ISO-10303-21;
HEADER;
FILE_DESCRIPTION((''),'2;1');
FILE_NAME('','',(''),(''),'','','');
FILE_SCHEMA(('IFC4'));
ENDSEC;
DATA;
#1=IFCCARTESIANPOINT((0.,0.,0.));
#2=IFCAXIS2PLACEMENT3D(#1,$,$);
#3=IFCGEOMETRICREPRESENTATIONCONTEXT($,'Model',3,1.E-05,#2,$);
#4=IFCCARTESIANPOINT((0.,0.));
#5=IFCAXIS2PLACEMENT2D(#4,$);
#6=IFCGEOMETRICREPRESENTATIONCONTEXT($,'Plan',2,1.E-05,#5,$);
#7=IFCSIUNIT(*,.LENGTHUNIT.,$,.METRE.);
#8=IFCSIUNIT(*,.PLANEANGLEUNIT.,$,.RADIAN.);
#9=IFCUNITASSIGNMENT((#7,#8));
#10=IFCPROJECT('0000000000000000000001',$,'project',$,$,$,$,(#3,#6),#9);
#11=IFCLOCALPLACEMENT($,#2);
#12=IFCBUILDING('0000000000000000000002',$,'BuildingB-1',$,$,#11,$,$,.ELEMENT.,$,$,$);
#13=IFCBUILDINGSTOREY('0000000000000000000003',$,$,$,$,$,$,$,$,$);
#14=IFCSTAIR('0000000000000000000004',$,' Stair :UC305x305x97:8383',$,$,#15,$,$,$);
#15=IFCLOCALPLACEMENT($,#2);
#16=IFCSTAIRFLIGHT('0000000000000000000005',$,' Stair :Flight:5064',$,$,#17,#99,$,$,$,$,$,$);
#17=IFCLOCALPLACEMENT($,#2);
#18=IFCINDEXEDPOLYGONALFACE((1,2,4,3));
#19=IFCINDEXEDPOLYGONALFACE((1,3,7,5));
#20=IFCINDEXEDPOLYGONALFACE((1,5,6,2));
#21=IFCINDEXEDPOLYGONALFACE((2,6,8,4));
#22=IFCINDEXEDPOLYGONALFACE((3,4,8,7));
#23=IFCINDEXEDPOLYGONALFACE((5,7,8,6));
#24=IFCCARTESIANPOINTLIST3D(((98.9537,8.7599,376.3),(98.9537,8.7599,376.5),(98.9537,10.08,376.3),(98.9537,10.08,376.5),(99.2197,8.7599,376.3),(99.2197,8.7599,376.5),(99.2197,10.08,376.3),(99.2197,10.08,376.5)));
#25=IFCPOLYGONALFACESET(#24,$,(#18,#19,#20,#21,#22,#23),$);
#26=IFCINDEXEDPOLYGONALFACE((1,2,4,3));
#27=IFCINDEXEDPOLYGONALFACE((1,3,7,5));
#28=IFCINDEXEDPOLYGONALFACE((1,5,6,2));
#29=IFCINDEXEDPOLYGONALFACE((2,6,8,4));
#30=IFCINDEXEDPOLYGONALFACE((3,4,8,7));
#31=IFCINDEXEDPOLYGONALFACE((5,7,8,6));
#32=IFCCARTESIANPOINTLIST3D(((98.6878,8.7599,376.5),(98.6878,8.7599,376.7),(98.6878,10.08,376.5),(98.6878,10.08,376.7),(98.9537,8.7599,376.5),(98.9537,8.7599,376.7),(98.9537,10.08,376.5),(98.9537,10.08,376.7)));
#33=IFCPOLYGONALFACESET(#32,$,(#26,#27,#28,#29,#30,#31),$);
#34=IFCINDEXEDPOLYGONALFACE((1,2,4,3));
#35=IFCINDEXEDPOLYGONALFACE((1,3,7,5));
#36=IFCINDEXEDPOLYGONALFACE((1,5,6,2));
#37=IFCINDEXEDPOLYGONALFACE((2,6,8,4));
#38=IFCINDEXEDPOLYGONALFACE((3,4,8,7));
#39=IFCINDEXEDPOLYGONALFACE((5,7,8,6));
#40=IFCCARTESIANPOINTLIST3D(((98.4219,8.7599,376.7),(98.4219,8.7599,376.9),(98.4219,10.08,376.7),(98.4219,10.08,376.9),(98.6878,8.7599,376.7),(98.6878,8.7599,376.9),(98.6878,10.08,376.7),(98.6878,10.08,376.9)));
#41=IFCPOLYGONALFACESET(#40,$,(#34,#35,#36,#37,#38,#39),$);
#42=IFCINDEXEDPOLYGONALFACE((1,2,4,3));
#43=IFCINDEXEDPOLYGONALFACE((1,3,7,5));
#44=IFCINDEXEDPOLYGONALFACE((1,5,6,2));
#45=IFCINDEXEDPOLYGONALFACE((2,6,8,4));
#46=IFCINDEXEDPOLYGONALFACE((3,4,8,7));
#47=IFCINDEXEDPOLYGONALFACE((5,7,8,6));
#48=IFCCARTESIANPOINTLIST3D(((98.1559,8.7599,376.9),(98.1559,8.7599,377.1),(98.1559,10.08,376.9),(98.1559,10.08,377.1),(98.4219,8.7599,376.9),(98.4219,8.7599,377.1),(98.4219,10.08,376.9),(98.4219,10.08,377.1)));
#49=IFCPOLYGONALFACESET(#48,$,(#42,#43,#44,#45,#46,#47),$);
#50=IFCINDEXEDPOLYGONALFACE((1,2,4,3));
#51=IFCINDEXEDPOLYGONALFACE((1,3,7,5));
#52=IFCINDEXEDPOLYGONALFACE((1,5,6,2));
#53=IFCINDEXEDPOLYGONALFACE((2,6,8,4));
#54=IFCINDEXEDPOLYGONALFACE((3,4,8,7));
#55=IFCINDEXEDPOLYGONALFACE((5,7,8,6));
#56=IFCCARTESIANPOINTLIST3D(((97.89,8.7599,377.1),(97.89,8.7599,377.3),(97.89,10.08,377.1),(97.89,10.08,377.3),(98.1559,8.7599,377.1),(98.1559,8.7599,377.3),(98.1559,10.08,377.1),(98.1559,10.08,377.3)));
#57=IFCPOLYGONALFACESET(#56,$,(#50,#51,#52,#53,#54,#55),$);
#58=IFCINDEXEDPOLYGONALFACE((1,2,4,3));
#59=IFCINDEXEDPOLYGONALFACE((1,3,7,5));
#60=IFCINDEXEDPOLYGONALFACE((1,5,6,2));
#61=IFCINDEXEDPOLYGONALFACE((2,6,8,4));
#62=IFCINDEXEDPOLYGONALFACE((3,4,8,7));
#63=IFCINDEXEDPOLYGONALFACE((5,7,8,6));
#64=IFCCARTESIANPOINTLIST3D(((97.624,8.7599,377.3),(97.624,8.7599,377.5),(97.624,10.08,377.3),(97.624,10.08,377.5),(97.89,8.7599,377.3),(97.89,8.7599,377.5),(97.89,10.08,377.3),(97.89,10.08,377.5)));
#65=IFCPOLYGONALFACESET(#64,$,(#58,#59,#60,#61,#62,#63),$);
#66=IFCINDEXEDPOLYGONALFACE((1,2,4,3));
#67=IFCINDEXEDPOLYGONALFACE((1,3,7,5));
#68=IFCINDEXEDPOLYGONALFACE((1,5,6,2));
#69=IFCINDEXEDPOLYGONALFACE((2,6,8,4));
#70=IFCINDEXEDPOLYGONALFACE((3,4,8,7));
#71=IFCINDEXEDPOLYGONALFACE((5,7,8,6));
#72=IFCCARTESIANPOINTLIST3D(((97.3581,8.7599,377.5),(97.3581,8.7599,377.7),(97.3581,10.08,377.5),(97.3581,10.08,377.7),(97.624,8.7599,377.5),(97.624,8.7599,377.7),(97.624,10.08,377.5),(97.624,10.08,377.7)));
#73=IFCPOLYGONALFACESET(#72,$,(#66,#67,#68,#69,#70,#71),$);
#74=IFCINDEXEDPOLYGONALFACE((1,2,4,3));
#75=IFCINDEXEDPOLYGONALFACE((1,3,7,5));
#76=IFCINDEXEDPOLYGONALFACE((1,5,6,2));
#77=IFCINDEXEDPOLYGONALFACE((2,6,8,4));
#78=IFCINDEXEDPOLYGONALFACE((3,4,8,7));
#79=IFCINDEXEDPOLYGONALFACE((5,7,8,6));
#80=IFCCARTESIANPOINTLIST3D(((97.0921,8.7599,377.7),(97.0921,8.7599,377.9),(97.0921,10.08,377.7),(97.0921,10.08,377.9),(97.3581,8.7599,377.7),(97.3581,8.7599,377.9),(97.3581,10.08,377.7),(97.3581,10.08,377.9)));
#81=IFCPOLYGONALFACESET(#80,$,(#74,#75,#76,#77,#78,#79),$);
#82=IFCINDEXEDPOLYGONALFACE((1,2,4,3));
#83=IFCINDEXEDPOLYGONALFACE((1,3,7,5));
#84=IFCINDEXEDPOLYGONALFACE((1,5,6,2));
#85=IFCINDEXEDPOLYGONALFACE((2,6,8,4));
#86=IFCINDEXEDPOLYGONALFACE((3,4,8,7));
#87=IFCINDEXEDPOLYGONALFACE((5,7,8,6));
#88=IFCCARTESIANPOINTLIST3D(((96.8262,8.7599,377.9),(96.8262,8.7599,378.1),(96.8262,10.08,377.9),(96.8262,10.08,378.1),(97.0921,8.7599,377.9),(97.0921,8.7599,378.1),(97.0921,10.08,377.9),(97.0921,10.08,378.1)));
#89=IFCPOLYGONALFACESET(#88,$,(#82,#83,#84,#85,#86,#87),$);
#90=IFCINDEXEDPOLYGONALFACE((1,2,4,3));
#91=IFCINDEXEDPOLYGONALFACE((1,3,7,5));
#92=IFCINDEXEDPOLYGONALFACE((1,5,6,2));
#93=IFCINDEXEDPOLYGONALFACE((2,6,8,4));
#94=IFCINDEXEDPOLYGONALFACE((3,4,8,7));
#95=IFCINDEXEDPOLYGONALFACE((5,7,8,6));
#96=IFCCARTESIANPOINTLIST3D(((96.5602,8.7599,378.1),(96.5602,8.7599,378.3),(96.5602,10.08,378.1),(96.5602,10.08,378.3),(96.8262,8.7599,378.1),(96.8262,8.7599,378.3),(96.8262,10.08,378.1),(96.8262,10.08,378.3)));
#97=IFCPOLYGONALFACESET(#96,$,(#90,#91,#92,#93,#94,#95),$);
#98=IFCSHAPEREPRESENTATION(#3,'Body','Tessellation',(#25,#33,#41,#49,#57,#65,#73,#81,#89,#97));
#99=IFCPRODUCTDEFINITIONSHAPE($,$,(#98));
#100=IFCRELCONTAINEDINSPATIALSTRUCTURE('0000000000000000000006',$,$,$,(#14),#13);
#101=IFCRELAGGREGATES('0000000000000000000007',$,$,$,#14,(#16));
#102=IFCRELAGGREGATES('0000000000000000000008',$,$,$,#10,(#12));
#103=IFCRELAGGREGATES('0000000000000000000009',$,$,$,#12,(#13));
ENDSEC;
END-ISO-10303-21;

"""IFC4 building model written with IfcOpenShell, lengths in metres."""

from ifc_helpers import new_model, si_unit, frame, origin, origin_2d, place, context, project, spatial, polyline, outline, extrude, element, aggregate, save


model = new_model("IFC4")

# Units and contexts
model_context = context("Model", 3, precision=1e-05, world=origin())
plan_context = context("Plan", 2, precision=1e-05, world=origin_2d())
ifc_project = project(units=[si_unit("LENGTHUNIT", "METRE"), si_unit("PLANEANGLEUNIT", "RADIAN")], contexts=[model_context, plan_context])

# Building, storey
building_placement = place(None, origin())
building = spatial("IfcBuilding", under=ifc_project, at=building_placement, Name="BuildingB-1", CompositionType="ELEMENT")
storey = spatial("IfcBuildingStorey", under=building)

# Stair, stair flight
stair_1 = element("IfcStair", 1, inside=storey, Name=" Stair :UC305x305x97:8383")
stair_flight_1 = element("IfcStairFlight", 2, Name=" Stair :Flight:5064", context=model_context, shape_type="SweptSolid", body=[
    extrude(outline(polyline([(98.9537, 8.7599, 376.5), (98.9537, 10.08, 376.5), (99.2197, 10.08, 376.5), (99.2197, 8.7599, 376.5), (98.9537, 8.7599, 376.5)])), origin(), (0.0, 0.0, -1.0), 0.2),
    extrude(outline(polyline([(98.6878, 8.7599, 376.5), (98.6878, 10.08, 376.5), (98.9537, 10.08, 376.5), (98.9537, 8.7599, 376.5), (98.6878, 8.7599, 376.5)])), frame((0.0, 0.0, 0.2)), (0.0, 0.0, -1.0), 0.2),
    extrude(outline(polyline([(98.4219, 8.7599, 376.5), (98.4219, 10.08, 376.5), (98.6878, 10.08, 376.5), (98.6878, 8.7599, 376.5), (98.4219, 8.7599, 376.5)])), frame((0.0, 0.0, 0.4)), (0.0, 0.0, -1.0), 0.2),
    extrude(outline(polyline([(98.1559, 8.7599, 376.5), (98.1559, 10.08, 376.5), (98.4219, 10.08, 376.5), (98.4219, 8.7599, 376.5), (98.1559, 8.7599, 376.5)])), frame((0.0, 0.0, 0.6)), (0.0, 0.0, -1.0), 0.2),
    extrude(outline(polyline([(97.89, 8.7599, 376.5), (97.89, 10.08, 376.5), (98.1559, 10.08, 376.5), (98.1559, 8.7599, 376.5), (97.89, 8.7599, 376.5)])), frame((0.0, 0.0, 0.8)), (0.0, 0.0, -1.0), 0.2),
    extrude(outline(polyline([(97.624, 8.7599, 376.5), (97.624, 10.08, 376.5), (97.89, 10.08, 376.5), (97.89, 8.7599, 376.5), (97.624, 8.7599, 376.5)])), frame((0.0, 0.0, 1.0)), (0.0, 0.0, -1.0), 0.2),
    extrude(outline(polyline([(97.3581, 8.7599, 376.5), (97.3581, 10.08, 376.5), (97.624, 10.08, 376.5), (97.624, 8.7599, 376.5), (97.3581, 8.7599, 376.5)])), frame((0.0, 0.0, 1.2)), (0.0, 0.0, -1.0), 0.2),
    extrude(outline(polyline([(97.0921, 8.7599, 376.5), (97.0921, 10.08, 376.5), (97.3581, 10.08, 376.5), (97.3581, 8.7599, 376.5), (97.0921, 8.7599, 376.5)])), frame((0.0, 0.0, 1.4)), (0.0, 0.0, -1.0), 0.2),
    extrude(outline(polyline([(96.8262, 8.7599, 376.5), (96.8262, 10.08, 376.5), (97.0921, 10.08, 376.5), (97.0921, 8.7599, 376.5), (96.8262, 8.7599, 376.5)])), frame((0.0, 0.0, 1.6)), (0.0, 0.0, -1.0), 0.2),
    extrude(outline(polyline([(96.5602, 8.7599, 376.5), (96.5602, 10.08, 376.5), (96.8262, 10.08, 376.5), (96.8262, 8.7599, 376.5), (96.5602, 8.7599, 376.5)])), frame((0.0, 0.0, 1.8)), (0.0, 0.0, -1.0), 0.2),
])
aggregate(stair_1, [stair_flight_1])

save(model, "model.ifc")
